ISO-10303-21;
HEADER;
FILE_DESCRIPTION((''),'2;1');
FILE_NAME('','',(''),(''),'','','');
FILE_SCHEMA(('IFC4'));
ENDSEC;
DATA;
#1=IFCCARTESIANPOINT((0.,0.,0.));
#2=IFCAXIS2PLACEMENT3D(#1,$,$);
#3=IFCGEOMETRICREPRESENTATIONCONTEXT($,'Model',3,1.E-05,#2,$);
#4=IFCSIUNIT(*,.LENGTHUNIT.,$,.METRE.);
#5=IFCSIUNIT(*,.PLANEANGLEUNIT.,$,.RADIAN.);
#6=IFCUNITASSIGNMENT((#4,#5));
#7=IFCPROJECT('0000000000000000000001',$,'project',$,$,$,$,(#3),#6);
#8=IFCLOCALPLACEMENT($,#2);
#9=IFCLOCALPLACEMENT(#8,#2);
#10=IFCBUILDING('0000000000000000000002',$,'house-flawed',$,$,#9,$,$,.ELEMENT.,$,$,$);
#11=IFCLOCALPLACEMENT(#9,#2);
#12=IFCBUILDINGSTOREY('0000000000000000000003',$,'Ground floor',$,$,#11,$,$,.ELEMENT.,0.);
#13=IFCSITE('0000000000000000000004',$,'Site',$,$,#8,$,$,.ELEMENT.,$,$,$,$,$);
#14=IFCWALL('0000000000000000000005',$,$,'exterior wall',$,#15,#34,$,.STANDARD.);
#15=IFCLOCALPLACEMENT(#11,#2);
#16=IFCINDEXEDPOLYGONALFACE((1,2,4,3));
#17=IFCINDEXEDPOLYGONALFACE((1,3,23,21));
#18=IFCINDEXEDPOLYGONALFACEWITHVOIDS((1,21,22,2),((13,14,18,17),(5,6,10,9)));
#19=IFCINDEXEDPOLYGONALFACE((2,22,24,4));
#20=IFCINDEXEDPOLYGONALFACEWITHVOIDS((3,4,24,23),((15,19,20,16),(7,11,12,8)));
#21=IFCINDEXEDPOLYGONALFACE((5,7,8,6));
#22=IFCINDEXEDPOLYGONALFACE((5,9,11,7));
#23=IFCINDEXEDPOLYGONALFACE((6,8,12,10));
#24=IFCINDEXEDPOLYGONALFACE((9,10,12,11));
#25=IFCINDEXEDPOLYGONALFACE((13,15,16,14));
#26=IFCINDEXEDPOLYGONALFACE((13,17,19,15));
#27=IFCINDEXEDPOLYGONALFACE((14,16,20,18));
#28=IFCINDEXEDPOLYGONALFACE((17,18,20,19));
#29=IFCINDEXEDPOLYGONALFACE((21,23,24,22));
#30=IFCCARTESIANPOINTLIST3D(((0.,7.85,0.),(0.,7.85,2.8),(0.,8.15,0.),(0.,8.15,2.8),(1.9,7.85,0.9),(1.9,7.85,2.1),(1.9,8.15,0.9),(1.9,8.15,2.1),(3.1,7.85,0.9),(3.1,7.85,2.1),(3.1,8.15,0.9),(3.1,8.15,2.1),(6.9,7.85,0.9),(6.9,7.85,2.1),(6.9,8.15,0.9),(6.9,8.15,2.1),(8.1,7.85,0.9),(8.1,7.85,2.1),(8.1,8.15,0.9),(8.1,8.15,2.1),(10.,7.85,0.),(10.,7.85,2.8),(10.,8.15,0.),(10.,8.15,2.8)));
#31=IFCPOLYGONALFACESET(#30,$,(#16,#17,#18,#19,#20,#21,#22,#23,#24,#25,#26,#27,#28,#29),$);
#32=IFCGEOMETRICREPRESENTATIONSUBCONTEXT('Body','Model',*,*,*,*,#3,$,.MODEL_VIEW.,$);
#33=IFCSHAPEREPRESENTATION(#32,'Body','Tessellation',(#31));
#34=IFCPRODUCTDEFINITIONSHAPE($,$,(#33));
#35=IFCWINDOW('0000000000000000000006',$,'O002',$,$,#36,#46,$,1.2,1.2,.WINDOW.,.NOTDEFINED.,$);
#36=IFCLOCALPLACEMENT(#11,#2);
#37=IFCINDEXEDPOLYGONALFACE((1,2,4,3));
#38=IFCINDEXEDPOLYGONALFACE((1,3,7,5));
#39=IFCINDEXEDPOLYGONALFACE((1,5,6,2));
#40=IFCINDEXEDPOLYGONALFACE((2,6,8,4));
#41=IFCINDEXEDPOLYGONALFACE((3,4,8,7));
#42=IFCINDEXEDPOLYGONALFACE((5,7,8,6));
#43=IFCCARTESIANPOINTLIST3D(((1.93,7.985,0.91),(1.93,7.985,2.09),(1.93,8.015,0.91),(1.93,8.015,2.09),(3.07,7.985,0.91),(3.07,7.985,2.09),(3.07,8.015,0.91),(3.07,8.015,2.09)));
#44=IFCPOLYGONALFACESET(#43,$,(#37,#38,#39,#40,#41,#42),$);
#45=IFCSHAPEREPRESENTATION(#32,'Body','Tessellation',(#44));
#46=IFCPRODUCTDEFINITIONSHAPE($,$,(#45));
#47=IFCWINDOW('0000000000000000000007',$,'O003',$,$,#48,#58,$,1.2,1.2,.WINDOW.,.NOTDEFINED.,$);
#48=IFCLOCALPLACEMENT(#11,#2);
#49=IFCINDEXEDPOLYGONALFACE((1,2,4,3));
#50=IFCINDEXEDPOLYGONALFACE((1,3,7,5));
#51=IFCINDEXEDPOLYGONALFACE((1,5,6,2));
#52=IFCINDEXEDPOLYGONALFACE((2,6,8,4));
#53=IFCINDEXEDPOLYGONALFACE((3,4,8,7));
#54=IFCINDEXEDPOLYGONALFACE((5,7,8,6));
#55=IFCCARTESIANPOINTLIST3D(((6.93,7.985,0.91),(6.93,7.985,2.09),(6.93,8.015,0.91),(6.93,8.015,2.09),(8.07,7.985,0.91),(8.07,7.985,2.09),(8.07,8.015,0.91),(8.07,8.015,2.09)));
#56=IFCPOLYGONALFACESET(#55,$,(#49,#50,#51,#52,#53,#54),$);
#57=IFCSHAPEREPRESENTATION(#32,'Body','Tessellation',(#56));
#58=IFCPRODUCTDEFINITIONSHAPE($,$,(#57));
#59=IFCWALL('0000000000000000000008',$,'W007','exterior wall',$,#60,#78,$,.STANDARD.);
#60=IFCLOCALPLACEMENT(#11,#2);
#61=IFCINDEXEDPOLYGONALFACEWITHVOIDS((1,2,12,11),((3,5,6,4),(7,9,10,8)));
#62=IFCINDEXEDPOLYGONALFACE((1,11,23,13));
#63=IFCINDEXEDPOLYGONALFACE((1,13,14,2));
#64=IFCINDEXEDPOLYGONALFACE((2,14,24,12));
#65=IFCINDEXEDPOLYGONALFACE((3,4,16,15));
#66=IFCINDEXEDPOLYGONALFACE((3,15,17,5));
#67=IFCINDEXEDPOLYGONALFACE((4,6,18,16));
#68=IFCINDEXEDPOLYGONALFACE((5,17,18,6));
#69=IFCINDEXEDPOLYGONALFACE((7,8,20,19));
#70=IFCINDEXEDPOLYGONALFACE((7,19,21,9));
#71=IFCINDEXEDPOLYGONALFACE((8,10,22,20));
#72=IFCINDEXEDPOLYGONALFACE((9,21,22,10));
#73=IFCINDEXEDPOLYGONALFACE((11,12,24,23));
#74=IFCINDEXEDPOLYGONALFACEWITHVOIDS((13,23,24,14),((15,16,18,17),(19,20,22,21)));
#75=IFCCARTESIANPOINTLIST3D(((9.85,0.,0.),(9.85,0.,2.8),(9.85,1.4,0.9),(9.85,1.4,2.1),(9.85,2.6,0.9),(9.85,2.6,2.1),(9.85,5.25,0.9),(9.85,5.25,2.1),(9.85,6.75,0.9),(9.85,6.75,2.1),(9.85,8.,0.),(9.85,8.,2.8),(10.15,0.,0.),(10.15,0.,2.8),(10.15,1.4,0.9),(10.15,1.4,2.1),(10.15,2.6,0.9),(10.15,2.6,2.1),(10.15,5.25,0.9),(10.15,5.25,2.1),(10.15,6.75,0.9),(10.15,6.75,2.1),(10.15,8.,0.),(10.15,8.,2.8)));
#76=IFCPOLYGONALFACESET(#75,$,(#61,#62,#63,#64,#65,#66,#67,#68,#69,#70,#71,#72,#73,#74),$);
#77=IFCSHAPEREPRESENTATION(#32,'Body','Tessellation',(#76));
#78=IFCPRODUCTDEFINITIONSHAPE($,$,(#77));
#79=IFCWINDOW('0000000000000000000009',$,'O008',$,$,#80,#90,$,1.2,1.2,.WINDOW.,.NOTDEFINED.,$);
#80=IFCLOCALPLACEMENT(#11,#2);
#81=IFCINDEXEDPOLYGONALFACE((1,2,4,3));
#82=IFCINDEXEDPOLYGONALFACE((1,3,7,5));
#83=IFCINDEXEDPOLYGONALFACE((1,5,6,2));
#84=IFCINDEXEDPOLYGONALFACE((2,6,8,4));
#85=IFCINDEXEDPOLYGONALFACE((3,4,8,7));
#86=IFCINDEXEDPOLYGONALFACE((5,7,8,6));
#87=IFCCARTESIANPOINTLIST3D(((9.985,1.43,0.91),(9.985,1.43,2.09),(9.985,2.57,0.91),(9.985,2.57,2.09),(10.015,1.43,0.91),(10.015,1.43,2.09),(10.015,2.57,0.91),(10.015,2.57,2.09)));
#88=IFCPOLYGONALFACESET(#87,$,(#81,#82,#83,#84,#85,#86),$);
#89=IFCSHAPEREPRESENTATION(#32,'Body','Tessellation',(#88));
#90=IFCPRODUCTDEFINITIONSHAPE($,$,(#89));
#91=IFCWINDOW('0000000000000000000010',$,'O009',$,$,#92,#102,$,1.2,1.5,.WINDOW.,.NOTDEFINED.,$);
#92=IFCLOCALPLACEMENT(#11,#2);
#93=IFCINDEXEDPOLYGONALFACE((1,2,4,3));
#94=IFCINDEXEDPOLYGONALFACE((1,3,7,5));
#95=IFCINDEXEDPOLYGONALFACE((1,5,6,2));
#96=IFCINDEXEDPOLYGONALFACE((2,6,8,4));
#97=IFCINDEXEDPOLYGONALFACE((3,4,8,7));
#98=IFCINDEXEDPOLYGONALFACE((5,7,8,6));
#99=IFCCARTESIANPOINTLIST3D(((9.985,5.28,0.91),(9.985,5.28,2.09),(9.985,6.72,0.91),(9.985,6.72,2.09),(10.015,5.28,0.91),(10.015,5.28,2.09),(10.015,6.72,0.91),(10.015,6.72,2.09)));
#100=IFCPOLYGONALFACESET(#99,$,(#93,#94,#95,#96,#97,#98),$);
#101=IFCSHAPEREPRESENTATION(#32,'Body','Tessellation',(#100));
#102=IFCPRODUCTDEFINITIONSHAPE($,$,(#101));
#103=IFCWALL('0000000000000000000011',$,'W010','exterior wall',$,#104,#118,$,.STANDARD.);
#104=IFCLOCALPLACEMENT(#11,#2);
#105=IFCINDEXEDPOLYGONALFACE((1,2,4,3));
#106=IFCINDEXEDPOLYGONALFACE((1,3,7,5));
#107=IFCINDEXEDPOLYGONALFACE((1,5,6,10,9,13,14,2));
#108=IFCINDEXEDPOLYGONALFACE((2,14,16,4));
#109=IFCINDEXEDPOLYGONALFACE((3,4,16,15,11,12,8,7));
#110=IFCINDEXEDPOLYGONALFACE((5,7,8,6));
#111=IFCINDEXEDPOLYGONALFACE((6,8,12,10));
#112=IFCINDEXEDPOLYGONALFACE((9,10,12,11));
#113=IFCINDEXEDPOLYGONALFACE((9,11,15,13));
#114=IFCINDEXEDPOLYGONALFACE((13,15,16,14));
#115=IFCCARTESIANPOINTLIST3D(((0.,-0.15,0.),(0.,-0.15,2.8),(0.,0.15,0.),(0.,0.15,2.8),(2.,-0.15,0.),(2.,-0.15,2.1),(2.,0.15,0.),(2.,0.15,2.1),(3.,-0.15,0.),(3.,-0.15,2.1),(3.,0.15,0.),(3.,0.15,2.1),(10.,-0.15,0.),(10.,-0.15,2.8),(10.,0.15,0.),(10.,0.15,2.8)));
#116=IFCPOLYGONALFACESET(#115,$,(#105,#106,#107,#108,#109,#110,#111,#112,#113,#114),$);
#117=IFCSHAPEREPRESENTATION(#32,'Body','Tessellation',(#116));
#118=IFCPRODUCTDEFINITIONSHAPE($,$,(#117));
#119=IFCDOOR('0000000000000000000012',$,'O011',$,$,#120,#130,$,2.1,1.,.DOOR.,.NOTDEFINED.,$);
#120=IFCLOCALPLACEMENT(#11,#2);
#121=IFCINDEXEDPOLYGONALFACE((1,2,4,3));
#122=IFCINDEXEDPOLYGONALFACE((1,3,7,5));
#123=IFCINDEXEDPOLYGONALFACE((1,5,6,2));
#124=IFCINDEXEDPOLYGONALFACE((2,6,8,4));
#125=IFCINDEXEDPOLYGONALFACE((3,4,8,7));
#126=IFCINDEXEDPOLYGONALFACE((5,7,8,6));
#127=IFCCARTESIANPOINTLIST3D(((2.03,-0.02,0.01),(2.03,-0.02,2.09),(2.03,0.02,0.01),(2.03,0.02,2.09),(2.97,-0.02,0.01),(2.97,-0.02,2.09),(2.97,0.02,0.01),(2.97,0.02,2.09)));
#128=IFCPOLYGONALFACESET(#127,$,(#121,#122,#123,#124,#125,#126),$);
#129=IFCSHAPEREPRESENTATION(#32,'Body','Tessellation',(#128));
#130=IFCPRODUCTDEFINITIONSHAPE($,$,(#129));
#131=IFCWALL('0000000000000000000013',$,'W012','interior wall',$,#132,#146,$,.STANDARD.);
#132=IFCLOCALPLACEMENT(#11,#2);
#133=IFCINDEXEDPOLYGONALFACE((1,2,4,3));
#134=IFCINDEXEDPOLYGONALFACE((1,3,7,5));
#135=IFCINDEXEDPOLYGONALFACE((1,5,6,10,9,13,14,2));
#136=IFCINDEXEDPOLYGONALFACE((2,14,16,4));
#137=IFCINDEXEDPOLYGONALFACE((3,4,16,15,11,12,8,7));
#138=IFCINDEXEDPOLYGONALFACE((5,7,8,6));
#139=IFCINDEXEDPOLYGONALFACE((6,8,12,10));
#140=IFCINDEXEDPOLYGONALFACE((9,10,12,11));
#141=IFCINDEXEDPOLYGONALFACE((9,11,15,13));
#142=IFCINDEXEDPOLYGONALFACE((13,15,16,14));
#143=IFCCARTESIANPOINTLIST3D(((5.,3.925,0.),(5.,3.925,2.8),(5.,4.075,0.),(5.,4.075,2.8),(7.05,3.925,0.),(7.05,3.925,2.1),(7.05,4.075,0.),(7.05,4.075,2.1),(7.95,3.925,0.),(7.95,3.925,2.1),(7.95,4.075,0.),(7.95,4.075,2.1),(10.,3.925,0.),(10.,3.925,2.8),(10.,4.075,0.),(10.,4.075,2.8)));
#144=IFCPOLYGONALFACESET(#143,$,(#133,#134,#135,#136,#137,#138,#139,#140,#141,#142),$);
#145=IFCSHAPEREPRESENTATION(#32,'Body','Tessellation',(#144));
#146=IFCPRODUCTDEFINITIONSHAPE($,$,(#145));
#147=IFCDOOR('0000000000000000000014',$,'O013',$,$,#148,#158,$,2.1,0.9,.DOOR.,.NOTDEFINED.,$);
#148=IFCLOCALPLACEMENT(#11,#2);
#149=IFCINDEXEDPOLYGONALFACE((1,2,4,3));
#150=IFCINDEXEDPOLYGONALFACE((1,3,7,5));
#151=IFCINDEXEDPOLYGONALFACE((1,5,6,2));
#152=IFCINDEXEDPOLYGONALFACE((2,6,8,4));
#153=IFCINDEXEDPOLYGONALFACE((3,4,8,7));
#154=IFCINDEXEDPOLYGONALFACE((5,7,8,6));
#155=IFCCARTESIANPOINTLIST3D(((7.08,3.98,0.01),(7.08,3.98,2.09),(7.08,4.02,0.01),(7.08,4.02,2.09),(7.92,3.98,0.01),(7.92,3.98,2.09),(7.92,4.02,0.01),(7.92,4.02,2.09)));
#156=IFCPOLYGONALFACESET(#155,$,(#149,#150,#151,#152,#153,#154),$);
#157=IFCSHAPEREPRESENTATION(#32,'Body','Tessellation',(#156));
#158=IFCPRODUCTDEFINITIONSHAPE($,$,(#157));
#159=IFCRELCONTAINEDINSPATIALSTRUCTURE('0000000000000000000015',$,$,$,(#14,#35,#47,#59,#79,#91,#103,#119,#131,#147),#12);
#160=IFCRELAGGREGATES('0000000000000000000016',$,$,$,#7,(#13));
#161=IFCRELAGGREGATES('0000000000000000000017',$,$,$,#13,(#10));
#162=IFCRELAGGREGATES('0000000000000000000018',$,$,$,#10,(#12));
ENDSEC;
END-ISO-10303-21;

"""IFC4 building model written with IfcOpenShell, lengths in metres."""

from ifc_helpers import new_model, si_unit, frame, origin, origin_2d, place, context, subcontext, project, spatial, rectangle, extrude, element, fill, save


model = new_model("IFC4")

# Units and contexts
model_context = context("Model", 3, precision=1e-05, world=origin())
body_context = subcontext(model_context, "Body", "Model", "MODEL_VIEW")
ifc_project = project(units=[si_unit("LENGTHUNIT", "METRE"), si_unit("PLANEANGLEUNIT", "RADIAN")], contexts=[model_context])

# Site, building, storey
site_placement = place(None, origin())
site = spatial("IfcSite", under=ifc_project, at=site_placement, Name="Site", CompositionType="ELEMENT")
building_placement = place(site_placement, origin())
building = spatial("IfcBuilding", under=site, at=building_placement, Name="house-flawed", CompositionType="ELEMENT")
storey_placement = place(building_placement, origin())
storey = spatial("IfcBuildingStorey", under=building, at=storey_placement, Name="Ground floor", CompositionType="ELEMENT", Elevation=0.0)

# Walls, openings, windows
wall_1_placement = place(storey_placement, frame((5.0, 8.0, 0.0), z_axis=(0.0, 0.0, 1.0), x_axis=(1.0, 0.0, 0.0)))
wall_1 = element("IfcWall", 1, at=wall_1_placement, inside=storey, Description="exterior wall", PredefinedType="STANDARD", context=body_context, shape_type="SweptSolid", body=[
    extrude(rectangle(XDim=10.0, YDim=0.3, at=origin_2d()), origin(), (0.0, 0.0, 1.0), 2.8),
])
opening_1_placement = place(wall_1_placement, frame((-2.5, 0.0, 0.9)))
opening_1 = element("IfcOpeningElement", 2, at=opening_1_placement, cuts=wall_1, PredefinedType="OPENING", context=body_context, shape_type="SweptSolid", body=[
    extrude(rectangle(XDim=1.2, YDim=0.36, at=origin_2d()), origin(), (0.0, 0.0, 1.0), 1.2),
])
opening_2_placement = place(wall_1_placement, frame((2.5, 0.0, 0.9)))
opening_2 = element("IfcOpeningElement", 3, at=opening_2_placement, cuts=wall_1, PredefinedType="OPENING", context=body_context, shape_type="SweptSolid", body=[
    extrude(rectangle(XDim=1.2, YDim=0.36, at=origin_2d()), origin(), (0.0, 0.0, 1.0), 1.2),
])
window_1_placement = place(wall_1_placement, frame((-2.5, 0.0, 0.9)))
window_1 = element("IfcWindow", 4, at=window_1_placement, inside=storey, Name="O002", OverallHeight=1.2, OverallWidth=1.2, PartitioningType="NOTDEFINED", PredefinedType="WINDOW", context=body_context, shape_type="SweptSolid", body=[
    extrude(rectangle(XDim=1.14, YDim=0.03, at=origin_2d()), frame((0.0, 0.0, 0.01)), (0.0, 0.0, 1.0), 1.18),
])
fill(opening_1, window_1)
window_2_placement = place(wall_1_placement, frame((2.5, 0.0, 0.9)))
window_2 = element("IfcWindow", 5, at=window_2_placement, inside=storey, Name="O003", OverallHeight=1.2, OverallWidth=1.2, PartitioningType="NOTDEFINED", PredefinedType="WINDOW", context=body_context, shape_type="SweptSolid", body=[
    extrude(rectangle(XDim=1.14, YDim=0.03, at=origin_2d()), frame((0.0, 0.0, 0.01)), (0.0, 0.0, 1.0), 1.18),
])
fill(opening_2, window_2)
wall_2_placement = place(storey_placement, frame((10.0, 4.0, 0.0), z_axis=(0.0, 0.0, 1.0), x_axis=(0.0, 1.0, 0.0)))
wall_2 = element("IfcWall", 6, at=wall_2_placement, inside=storey, Name="W007", Description="exterior wall", PredefinedType="STANDARD", context=body_context, shape_type="SweptSolid", body=[
    extrude(rectangle(XDim=8.0, YDim=0.3, at=origin_2d()), origin(), (0.0, 0.0, 1.0), 2.8),
])
opening_3_placement = place(wall_2_placement, frame((-2.0, 0.0, 0.9)))
opening_3 = element("IfcOpeningElement", 7, at=opening_3_placement, cuts=wall_2, PredefinedType="OPENING", context=body_context, shape_type="SweptSolid", body=[
    extrude(rectangle(XDim=1.2, YDim=0.36, at=origin_2d()), origin(), (0.0, 0.0, 1.0), 1.2),
])
opening_4_placement = place(wall_2_placement, frame((2.0, 0.0, 0.9)))
opening_4 = element("IfcOpeningElement", 8, at=opening_4_placement, cuts=wall_2, PredefinedType="OPENING", context=body_context, shape_type="SweptSolid", body=[
    extrude(rectangle(XDim=1.5, YDim=0.36, at=origin_2d()), origin(), (0.0, 0.0, 1.0), 1.2),
])
window_3_placement = place(wall_2_placement, frame((-2.0, 0.0, 0.9)))
window_3 = element("IfcWindow", 9, at=window_3_placement, inside=storey, Name="O008", OverallHeight=1.2, OverallWidth=1.2, PartitioningType="NOTDEFINED", PredefinedType="WINDOW", context=body_context, shape_type="SweptSolid", body=[
    extrude(rectangle(XDim=1.14, YDim=0.03, at=origin_2d()), frame((0.0, 0.0, 0.01)), (0.0, 0.0, 1.0), 1.18),
])
fill(opening_3, window_3)
window_4_placement = place(wall_2_placement, frame((2.0, 0.0, 0.9)))
window_4 = element("IfcWindow", 10, at=window_4_placement, inside=storey, Name="O009", OverallHeight=1.2, OverallWidth=1.5, PartitioningType="NOTDEFINED", PredefinedType="WINDOW", context=body_context, shape_type="SweptSolid", body=[
    extrude(rectangle(XDim=1.44, YDim=0.03, at=origin_2d()), frame((0.0, 0.0, 0.01)), (0.0, 0.0, 1.0), 1.18),
])
fill(opening_4, window_4)

# Walls, openings, doors
wall_3_placement = place(storey_placement, frame((5.0, 0.0, 0.0), z_axis=(0.0, 0.0, 1.0), x_axis=(1.0, 0.0, 0.0)))
wall_3 = element("IfcWall", 11, at=wall_3_placement, inside=storey, Name="W010", Description="exterior wall", PredefinedType="STANDARD", context=body_context, shape_type="SweptSolid", body=[
    extrude(rectangle(XDim=10.0, YDim=0.3, at=origin_2d()), origin(), (0.0, 0.0, 1.0), 2.8),
])
opening_5_placement = place(wall_3_placement, frame((-2.5, 0.0, 0.0)))
opening_5 = element("IfcOpeningElement", 12, at=opening_5_placement, cuts=wall_3, PredefinedType="OPENING", context=body_context, shape_type="SweptSolid", body=[
    extrude(rectangle(XDim=1.0, YDim=0.36, at=origin_2d()), origin(), (0.0, 0.0, 1.0), 2.1),
])
door_1_placement = place(wall_3_placement, frame((-2.5, 0.0, 0.0)))
door_1 = element("IfcDoor", 13, at=door_1_placement, inside=storey, Name="O011", OperationType="NOTDEFINED", OverallHeight=2.1, OverallWidth=1.0, PredefinedType="DOOR", context=body_context, shape_type="SweptSolid", body=[
    extrude(rectangle(XDim=0.94, YDim=0.04, at=origin_2d()), frame((0.0, 0.0, 0.01)), (0.0, 0.0, 1.0), 2.08),
])
fill(opening_5, door_1)
wall_4_placement = place(storey_placement, frame((7.5, 4.0, 0.0), z_axis=(0.0, 0.0, 1.0), x_axis=(1.0, 0.0, 0.0)))
wall_4 = element("IfcWall", 14, at=wall_4_placement, inside=storey, Name="W012", Description="interior wall", PredefinedType="STANDARD", context=body_context, shape_type="SweptSolid", body=[
    extrude(rectangle(XDim=5.0, YDim=0.15, at=origin_2d()), origin(), (0.0, 0.0, 1.0), 2.8),
])
opening_6_placement = place(wall_4_placement, origin())
opening_6 = element("IfcOpeningElement", 15, at=opening_6_placement, cuts=wall_4, PredefinedType="OPENING", context=body_context, shape_type="SweptSolid", body=[
    extrude(rectangle(XDim=0.9, YDim=0.18, at=origin_2d()), origin(), (0.0, 0.0, 1.0), 2.1),
])
door_2_placement = place(wall_4_placement, origin())
door_2 = element("IfcDoor", 16, at=door_2_placement, inside=storey, Name="O013", OperationType="NOTDEFINED", OverallHeight=2.1, OverallWidth=0.9, PredefinedType="DOOR", context=body_context, shape_type="SweptSolid", body=[
    extrude(rectangle(XDim=0.84, YDim=0.04, at=origin_2d()), frame((0.0, 0.0, 0.01)), (0.0, 0.0, 1.0), 2.08),
])
fill(opening_6, door_2)

save(model, "model.ifc")
